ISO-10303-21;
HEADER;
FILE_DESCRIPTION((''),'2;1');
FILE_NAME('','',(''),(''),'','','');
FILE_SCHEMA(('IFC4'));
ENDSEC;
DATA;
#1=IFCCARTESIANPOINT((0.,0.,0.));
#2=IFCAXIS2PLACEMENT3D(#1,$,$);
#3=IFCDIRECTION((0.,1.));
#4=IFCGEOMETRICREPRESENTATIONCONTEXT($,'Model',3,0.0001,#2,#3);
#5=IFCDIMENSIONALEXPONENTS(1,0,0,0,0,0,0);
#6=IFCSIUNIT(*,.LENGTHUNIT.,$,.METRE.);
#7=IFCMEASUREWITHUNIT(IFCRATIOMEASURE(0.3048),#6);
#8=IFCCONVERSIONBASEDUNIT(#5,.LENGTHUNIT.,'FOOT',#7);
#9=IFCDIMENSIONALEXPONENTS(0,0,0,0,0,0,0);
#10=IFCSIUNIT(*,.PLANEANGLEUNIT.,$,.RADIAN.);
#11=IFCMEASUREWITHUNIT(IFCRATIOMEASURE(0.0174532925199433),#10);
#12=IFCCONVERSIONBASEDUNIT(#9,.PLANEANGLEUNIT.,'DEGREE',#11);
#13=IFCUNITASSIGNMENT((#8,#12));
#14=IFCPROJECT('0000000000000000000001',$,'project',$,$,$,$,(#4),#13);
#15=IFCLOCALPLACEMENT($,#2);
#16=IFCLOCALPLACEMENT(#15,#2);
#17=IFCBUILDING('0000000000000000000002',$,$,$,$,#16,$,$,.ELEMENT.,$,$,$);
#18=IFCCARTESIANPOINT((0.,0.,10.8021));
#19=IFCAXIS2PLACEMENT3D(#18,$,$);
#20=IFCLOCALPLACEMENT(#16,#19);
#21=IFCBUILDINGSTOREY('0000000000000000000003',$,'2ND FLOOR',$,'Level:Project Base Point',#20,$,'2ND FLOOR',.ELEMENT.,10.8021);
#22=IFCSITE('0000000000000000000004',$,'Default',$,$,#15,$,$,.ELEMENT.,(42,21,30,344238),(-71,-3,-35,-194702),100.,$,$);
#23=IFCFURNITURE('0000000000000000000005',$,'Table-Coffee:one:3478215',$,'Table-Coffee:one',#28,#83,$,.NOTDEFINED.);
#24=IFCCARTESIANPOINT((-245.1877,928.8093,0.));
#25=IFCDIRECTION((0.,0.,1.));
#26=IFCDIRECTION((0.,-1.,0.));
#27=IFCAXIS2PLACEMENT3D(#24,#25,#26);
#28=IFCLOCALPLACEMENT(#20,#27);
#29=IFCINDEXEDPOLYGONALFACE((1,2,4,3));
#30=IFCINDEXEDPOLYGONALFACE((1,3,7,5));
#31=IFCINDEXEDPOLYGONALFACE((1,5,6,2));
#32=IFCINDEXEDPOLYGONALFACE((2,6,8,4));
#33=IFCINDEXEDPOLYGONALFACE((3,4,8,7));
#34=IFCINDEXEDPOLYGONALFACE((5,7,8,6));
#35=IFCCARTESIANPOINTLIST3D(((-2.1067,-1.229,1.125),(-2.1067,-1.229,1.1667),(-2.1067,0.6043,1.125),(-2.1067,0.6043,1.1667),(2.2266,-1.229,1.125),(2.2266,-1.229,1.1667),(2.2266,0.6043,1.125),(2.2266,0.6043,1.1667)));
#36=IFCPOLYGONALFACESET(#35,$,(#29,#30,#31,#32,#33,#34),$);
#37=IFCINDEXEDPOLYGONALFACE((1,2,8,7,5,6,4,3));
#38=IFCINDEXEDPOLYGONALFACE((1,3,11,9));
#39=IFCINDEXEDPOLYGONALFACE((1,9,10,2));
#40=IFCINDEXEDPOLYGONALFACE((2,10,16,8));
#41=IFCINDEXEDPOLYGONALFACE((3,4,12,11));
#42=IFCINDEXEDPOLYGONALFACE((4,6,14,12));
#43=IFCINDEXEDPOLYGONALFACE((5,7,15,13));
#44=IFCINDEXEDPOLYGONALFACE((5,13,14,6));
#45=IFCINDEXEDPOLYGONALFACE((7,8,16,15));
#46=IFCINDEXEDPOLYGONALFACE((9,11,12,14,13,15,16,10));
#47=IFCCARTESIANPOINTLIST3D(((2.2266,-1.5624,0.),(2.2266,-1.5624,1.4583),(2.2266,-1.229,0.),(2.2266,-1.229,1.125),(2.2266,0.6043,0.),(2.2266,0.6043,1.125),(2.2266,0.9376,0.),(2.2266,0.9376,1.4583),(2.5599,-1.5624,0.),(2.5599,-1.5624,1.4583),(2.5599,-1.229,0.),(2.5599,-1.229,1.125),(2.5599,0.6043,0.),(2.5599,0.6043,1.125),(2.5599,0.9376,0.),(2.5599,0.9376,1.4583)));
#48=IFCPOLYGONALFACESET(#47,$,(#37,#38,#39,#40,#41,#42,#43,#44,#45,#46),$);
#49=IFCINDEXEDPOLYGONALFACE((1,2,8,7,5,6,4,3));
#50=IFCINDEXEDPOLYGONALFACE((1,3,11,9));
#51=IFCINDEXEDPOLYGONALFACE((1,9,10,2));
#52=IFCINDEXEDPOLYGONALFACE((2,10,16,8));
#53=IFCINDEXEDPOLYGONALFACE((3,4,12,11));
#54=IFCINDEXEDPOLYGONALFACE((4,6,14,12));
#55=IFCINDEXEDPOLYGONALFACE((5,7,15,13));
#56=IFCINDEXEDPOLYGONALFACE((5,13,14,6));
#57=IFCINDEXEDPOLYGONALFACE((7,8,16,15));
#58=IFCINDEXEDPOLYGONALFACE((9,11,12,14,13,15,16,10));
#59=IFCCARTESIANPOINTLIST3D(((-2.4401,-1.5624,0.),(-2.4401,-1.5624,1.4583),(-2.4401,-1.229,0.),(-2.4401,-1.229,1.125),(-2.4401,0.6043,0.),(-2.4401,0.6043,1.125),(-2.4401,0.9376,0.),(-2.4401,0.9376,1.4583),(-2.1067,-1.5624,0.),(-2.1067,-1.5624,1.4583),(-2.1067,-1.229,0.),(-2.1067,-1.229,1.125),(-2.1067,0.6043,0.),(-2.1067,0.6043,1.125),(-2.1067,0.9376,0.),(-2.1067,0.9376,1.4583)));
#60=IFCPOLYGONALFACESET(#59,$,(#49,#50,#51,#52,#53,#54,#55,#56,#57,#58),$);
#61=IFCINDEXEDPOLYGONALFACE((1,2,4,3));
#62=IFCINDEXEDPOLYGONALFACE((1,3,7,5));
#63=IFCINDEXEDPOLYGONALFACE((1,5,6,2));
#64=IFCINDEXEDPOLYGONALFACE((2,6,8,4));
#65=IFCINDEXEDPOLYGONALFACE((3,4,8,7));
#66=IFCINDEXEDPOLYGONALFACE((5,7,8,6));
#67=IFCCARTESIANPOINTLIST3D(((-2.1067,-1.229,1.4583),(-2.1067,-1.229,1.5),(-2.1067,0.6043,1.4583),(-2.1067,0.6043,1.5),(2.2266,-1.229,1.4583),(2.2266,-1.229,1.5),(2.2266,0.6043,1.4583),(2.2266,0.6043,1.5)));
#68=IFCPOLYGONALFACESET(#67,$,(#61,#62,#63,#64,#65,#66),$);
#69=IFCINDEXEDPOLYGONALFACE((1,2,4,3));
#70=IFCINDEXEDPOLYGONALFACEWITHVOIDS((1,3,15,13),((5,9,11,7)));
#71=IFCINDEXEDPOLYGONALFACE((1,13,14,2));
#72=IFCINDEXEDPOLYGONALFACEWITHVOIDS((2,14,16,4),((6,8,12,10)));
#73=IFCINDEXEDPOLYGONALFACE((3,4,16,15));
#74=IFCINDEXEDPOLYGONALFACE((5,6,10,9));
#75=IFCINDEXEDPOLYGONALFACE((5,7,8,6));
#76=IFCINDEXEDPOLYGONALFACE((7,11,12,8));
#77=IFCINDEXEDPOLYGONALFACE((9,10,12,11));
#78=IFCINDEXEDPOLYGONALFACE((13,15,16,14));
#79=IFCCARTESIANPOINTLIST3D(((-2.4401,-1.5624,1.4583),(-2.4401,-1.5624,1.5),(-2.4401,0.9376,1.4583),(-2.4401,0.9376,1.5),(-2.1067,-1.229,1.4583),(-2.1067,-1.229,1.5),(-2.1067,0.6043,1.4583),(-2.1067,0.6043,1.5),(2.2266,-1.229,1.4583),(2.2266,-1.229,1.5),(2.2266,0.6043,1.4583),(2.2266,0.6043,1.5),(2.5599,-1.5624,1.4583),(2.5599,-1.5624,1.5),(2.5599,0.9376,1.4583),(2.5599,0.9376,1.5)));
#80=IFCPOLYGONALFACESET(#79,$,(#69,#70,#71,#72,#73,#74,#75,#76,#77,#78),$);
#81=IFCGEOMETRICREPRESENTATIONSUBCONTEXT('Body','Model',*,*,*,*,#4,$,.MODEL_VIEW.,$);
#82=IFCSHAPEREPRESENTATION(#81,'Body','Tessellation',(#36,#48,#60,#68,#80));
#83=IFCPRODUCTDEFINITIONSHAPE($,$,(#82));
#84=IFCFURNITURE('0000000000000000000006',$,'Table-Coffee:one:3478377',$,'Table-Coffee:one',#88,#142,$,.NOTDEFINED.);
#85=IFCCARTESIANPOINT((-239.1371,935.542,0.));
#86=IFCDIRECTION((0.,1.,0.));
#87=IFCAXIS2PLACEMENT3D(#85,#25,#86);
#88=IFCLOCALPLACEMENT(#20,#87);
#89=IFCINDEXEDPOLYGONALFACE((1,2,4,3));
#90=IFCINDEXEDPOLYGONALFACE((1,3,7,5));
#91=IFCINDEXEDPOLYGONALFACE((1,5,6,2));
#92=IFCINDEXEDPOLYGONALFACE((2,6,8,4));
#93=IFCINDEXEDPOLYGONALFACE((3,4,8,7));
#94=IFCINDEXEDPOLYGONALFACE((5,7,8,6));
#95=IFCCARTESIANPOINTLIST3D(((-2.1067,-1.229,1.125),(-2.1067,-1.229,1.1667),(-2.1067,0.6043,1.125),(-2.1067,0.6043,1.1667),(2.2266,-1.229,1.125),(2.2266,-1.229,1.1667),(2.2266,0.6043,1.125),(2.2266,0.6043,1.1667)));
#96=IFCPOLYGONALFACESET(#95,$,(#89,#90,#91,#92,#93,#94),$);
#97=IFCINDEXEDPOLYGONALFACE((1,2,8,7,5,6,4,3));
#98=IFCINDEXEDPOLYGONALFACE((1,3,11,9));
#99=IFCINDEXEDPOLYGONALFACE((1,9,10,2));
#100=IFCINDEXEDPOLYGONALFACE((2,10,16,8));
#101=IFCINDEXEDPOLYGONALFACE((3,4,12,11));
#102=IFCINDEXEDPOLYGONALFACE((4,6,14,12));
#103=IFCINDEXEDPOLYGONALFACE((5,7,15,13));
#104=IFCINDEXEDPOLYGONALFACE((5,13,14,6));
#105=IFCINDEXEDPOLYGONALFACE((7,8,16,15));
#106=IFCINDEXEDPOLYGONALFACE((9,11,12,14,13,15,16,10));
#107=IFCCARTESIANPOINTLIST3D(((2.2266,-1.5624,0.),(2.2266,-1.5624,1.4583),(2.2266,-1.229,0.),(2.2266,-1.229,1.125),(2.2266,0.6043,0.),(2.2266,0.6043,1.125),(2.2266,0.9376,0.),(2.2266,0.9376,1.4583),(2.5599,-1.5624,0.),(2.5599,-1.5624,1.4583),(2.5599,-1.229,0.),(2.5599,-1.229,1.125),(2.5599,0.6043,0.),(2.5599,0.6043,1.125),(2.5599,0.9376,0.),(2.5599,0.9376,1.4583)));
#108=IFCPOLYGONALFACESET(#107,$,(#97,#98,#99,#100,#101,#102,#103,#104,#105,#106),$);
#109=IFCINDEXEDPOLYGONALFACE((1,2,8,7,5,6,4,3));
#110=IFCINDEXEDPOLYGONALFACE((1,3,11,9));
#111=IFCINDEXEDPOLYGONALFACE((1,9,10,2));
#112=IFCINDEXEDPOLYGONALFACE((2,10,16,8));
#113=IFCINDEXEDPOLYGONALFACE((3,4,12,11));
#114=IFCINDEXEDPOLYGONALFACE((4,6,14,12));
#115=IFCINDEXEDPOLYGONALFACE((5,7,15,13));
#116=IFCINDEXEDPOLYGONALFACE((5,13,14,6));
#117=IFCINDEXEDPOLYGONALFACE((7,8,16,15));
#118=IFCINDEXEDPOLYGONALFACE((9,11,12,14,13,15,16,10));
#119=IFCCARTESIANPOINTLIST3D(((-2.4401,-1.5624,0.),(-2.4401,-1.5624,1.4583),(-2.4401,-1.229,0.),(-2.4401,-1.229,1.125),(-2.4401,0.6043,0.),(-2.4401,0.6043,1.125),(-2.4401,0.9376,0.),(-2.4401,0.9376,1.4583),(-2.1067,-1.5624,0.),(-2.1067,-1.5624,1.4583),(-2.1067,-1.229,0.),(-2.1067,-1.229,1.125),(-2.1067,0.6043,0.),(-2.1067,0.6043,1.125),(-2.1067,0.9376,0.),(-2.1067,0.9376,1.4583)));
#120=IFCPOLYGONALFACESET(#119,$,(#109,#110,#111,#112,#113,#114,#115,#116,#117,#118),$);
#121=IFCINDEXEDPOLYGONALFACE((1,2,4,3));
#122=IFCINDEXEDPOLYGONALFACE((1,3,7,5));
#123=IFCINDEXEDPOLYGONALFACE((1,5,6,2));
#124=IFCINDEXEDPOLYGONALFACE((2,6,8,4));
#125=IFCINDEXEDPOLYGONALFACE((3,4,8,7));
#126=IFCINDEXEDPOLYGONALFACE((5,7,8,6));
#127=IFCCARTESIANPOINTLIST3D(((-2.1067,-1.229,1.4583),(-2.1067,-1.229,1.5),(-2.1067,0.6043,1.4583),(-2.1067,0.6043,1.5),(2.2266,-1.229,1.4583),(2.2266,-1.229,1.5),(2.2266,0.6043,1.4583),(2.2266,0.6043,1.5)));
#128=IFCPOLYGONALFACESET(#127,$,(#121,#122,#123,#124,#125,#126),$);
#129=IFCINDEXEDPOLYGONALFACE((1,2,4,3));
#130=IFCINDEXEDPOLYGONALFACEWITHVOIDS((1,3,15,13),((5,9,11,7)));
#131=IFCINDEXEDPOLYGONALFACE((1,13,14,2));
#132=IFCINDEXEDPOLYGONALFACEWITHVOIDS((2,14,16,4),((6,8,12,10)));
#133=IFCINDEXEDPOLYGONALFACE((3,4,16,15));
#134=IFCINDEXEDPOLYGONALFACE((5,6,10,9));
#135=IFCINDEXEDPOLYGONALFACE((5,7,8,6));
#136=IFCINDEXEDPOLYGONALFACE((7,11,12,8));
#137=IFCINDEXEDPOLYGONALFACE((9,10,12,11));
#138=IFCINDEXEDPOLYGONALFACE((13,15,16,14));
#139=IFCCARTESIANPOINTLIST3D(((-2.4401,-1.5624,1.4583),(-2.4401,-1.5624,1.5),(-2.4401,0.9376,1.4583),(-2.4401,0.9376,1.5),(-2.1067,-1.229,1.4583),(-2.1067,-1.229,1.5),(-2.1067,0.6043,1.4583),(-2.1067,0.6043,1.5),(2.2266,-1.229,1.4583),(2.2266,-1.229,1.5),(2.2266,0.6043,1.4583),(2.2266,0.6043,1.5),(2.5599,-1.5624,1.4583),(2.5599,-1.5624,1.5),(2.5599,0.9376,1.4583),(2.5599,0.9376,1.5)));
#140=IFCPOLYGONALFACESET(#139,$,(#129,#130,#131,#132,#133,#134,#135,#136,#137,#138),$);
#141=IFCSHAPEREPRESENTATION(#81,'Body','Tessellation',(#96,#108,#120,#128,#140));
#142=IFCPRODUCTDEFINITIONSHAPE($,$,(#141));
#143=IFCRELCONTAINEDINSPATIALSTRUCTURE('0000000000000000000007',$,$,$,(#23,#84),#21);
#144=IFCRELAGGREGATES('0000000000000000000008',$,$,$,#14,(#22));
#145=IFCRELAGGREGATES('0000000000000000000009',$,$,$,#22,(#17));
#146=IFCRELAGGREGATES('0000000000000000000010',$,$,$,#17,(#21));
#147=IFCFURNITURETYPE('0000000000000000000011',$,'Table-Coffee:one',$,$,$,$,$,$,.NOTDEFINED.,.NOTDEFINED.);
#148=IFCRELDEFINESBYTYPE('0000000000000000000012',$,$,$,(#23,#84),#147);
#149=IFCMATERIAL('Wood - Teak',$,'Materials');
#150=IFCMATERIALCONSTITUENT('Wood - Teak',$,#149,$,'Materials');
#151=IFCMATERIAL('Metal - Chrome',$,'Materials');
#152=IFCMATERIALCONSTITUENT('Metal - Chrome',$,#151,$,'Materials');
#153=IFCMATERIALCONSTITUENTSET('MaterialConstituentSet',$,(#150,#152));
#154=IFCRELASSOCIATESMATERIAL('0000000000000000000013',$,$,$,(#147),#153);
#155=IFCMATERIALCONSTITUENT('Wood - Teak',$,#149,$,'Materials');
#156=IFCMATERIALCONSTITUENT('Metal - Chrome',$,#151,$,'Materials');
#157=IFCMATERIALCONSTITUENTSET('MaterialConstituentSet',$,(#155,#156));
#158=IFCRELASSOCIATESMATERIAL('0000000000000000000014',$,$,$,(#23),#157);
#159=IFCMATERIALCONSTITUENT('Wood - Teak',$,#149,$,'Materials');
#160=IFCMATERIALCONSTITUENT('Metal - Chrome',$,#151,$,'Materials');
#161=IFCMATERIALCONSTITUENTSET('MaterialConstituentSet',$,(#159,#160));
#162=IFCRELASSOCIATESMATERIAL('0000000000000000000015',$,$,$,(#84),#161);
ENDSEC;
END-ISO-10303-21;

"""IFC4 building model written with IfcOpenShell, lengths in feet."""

from ifc_helpers import new_model, entity, si_unit, converted_unit, direction, frame, origin, origin_2d_with_axis, place, context, subcontext, project, spatial, polyline, rectangle, outline, extrude, source, transform, mapped, material, constituent, constituent_set, type_object, type_shapes, element, save


model = new_model("IFC4")

# Units and contexts
model_context = context("Model", 3, precision=0.0001, world=origin(), true_north=direction((0.0, 1.0)))
body_context = subcontext(model_context, "Body", "Model", "MODEL_VIEW")
ifc_project = project(units=[converted_unit("LENGTHUNIT", "FOOT", entity("IfcRatioMeasure", 0.3048), si_unit("LENGTHUNIT", "METRE"), dimensions=[1, 0, 0, 0, 0, 0, 0]), converted_unit("PLANEANGLEUNIT", "DEGREE", entity("IfcRatioMeasure", 0.0174532925199433), si_unit("PLANEANGLEUNIT", "RADIAN"), dimensions=[0, 0, 0, 0, 0, 0, 0])], contexts=[model_context])

# Site, building, storey
site_placement = place(None, origin())
site = spatial("IfcSite", under=ifc_project, at=site_placement, Name="Default", CompositionType="ELEMENT", RefLatitude=(42, 21, 30, 344238), RefLongitude=(-71, -3, -35, -194702), RefElevation=100.0)
building_placement = place(site_placement, origin())
building = spatial("IfcBuilding", under=site, at=building_placement, CompositionType="ELEMENT")
storey_placement = place(building_placement, frame((0.0, 0.0, 10.8021)))
storey = spatial("IfcBuildingStorey", under=building, at=storey_placement, Name="2ND FLOOR", ObjectType="Level:Project Base Point", LongName="2ND FLOOR", CompositionType="ELEMENT", Elevation=10.8021)

# Furniture
ifc_material_1 = material(Name="Wood - Teak", Category="Materials")
ifc_constituent_1 = constituent(ifc_material_1, Name="Wood - Teak", Category="Materials")
ifc_material_2 = material(Name="Metal - Chrome", Category="Materials")
ifc_constituent_2 = constituent(ifc_material_2, Name="Metal - Chrome", Category="Materials")
ifc_constituent_set_1 = constituent_set(constituents=[ifc_constituent_1, ifc_constituent_2], Name="MaterialConstituentSet")
ifc_constituent_3 = constituent(ifc_material_1, Name="Wood - Teak", Category="Materials")
ifc_constituent_4 = constituent(ifc_material_2, Name="Metal - Chrome", Category="Materials")
ifc_constituent_set_2 = constituent_set(constituents=[ifc_constituent_3, ifc_constituent_4], Name="MaterialConstituentSet")
furniture_type_1 = type_object("IfcFurnitureType", Name="Table-Coffee:one", AssemblyPlace="NOTDEFINED", PredefinedType="NOTDEFINED", material=ifc_constituent_set_2)
shared_shape_1 = source(origin(), body_context, "Body", "SweptSolid", [
    extrude(rectangle(XDim=1.8333, YDim=4.3333, at=origin_2d_with_axis()), frame((0.0599, -0.3124, 1.125), z_axis=(0.0, 0.0, 1.0), x_axis=(0.0, 1.0, 0.0)), (0.0, 0.0, 1.0), 0.0417),
    extrude(outline(polyline([(-1.25, -0.6458), (-0.9167, -0.6458), (-0.9167, 0.4792), (0.9167, 0.4792), (0.9167, -0.6458), (1.25, -0.6458), (1.25, 0.8125), (-1.25, 0.8125), (-1.25, -0.6458)])), frame((2.2266, -0.3124, 0.6458), z_axis=(1.0, 0.0, 0.0), x_axis=(0.0, 1.0, 0.0)), (0.0, 0.0, 1.0), 0.3333),
    extrude(outline(polyline([(-0.8125, -1.25), (0.6458, -1.25), (0.6458, -0.9167), (-0.4792, -0.9167), (-0.4792, 0.9167), (0.6458, 0.9167), (0.6458, 1.25), (-0.8125, 1.25), (-0.8125, -1.25)])), frame((-2.4401, -0.3124, 0.6458), z_axis=(1.0, 0.0, 0.0), x_axis=(0.0, 0.0, -1.0)), (0.0, 0.0, 1.0), 0.3333),
    extrude(rectangle(XDim=1.8333, YDim=4.3333, at=origin_2d_with_axis()), frame((0.0599, -0.3124, 1.4583), z_axis=(0.0, 0.0, 1.0), x_axis=(0.0, 1.0, 0.0)), (0.0, 0.0, 1.0), 0.0417),
    extrude(outline(polyline([(-1.25, -2.5), (1.25, -2.5), (1.25, 2.5), (-1.25, 2.5), (-1.25, -2.5)]), holes=[polyline([(-0.9167, -2.1667), (-0.9167, 2.1667), (0.9167, 2.1667), (0.9167, -2.1667), (-0.9167, -2.1667)])]), frame((0.0599, -0.3124, 1.4583), z_axis=(0.0, 0.0, 1.0), x_axis=(0.0, 1.0, 0.0)), (0.0, 0.0, 1.0), 0.0417),
])
type_shapes(furniture_type_1, [shared_shape_1])
furniture_1_placement = place(storey_placement, frame((-245.1877, 928.8093, 0.0), z_axis=(0.0, 0.0, 1.0), x_axis=(0.0, -1.0, 0.0)))
element("IfcFurniture", 1, at=furniture_1_placement, inside=storey, type_object=furniture_type_1, material=ifc_constituent_set_1, Name="Table-Coffee:one:3478215", ObjectType="Table-Coffee:one", PredefinedType="NOTDEFINED", context=body_context, shape_type="MappedRepresentation", body=[
    mapped(shared_shape_1, transform((0.0, 0.0, 0.0), scale=1.0)),
])
ifc_constituent_5 = constituent(ifc_material_1, Name="Wood - Teak", Category="Materials")
ifc_constituent_6 = constituent(ifc_material_2, Name="Metal - Chrome", Category="Materials")
ifc_constituent_set_3 = constituent_set(constituents=[ifc_constituent_5, ifc_constituent_6], Name="MaterialConstituentSet")
furniture_2_placement = place(storey_placement, frame((-239.1371, 935.542, 0.0), z_axis=(0.0, 0.0, 1.0), x_axis=(0.0, 1.0, 0.0)))
element("IfcFurniture", 2, at=furniture_2_placement, inside=storey, type_object=furniture_type_1, material=ifc_constituent_set_3, Name="Table-Coffee:one:3478377", ObjectType="Table-Coffee:one", PredefinedType="NOTDEFINED", context=body_context, shape_type="MappedRepresentation", body=[
    mapped(shared_shape_1, transform((0.0, 0.0, 0.0), scale=1.0)),
])

save(model, "model.ifc")
